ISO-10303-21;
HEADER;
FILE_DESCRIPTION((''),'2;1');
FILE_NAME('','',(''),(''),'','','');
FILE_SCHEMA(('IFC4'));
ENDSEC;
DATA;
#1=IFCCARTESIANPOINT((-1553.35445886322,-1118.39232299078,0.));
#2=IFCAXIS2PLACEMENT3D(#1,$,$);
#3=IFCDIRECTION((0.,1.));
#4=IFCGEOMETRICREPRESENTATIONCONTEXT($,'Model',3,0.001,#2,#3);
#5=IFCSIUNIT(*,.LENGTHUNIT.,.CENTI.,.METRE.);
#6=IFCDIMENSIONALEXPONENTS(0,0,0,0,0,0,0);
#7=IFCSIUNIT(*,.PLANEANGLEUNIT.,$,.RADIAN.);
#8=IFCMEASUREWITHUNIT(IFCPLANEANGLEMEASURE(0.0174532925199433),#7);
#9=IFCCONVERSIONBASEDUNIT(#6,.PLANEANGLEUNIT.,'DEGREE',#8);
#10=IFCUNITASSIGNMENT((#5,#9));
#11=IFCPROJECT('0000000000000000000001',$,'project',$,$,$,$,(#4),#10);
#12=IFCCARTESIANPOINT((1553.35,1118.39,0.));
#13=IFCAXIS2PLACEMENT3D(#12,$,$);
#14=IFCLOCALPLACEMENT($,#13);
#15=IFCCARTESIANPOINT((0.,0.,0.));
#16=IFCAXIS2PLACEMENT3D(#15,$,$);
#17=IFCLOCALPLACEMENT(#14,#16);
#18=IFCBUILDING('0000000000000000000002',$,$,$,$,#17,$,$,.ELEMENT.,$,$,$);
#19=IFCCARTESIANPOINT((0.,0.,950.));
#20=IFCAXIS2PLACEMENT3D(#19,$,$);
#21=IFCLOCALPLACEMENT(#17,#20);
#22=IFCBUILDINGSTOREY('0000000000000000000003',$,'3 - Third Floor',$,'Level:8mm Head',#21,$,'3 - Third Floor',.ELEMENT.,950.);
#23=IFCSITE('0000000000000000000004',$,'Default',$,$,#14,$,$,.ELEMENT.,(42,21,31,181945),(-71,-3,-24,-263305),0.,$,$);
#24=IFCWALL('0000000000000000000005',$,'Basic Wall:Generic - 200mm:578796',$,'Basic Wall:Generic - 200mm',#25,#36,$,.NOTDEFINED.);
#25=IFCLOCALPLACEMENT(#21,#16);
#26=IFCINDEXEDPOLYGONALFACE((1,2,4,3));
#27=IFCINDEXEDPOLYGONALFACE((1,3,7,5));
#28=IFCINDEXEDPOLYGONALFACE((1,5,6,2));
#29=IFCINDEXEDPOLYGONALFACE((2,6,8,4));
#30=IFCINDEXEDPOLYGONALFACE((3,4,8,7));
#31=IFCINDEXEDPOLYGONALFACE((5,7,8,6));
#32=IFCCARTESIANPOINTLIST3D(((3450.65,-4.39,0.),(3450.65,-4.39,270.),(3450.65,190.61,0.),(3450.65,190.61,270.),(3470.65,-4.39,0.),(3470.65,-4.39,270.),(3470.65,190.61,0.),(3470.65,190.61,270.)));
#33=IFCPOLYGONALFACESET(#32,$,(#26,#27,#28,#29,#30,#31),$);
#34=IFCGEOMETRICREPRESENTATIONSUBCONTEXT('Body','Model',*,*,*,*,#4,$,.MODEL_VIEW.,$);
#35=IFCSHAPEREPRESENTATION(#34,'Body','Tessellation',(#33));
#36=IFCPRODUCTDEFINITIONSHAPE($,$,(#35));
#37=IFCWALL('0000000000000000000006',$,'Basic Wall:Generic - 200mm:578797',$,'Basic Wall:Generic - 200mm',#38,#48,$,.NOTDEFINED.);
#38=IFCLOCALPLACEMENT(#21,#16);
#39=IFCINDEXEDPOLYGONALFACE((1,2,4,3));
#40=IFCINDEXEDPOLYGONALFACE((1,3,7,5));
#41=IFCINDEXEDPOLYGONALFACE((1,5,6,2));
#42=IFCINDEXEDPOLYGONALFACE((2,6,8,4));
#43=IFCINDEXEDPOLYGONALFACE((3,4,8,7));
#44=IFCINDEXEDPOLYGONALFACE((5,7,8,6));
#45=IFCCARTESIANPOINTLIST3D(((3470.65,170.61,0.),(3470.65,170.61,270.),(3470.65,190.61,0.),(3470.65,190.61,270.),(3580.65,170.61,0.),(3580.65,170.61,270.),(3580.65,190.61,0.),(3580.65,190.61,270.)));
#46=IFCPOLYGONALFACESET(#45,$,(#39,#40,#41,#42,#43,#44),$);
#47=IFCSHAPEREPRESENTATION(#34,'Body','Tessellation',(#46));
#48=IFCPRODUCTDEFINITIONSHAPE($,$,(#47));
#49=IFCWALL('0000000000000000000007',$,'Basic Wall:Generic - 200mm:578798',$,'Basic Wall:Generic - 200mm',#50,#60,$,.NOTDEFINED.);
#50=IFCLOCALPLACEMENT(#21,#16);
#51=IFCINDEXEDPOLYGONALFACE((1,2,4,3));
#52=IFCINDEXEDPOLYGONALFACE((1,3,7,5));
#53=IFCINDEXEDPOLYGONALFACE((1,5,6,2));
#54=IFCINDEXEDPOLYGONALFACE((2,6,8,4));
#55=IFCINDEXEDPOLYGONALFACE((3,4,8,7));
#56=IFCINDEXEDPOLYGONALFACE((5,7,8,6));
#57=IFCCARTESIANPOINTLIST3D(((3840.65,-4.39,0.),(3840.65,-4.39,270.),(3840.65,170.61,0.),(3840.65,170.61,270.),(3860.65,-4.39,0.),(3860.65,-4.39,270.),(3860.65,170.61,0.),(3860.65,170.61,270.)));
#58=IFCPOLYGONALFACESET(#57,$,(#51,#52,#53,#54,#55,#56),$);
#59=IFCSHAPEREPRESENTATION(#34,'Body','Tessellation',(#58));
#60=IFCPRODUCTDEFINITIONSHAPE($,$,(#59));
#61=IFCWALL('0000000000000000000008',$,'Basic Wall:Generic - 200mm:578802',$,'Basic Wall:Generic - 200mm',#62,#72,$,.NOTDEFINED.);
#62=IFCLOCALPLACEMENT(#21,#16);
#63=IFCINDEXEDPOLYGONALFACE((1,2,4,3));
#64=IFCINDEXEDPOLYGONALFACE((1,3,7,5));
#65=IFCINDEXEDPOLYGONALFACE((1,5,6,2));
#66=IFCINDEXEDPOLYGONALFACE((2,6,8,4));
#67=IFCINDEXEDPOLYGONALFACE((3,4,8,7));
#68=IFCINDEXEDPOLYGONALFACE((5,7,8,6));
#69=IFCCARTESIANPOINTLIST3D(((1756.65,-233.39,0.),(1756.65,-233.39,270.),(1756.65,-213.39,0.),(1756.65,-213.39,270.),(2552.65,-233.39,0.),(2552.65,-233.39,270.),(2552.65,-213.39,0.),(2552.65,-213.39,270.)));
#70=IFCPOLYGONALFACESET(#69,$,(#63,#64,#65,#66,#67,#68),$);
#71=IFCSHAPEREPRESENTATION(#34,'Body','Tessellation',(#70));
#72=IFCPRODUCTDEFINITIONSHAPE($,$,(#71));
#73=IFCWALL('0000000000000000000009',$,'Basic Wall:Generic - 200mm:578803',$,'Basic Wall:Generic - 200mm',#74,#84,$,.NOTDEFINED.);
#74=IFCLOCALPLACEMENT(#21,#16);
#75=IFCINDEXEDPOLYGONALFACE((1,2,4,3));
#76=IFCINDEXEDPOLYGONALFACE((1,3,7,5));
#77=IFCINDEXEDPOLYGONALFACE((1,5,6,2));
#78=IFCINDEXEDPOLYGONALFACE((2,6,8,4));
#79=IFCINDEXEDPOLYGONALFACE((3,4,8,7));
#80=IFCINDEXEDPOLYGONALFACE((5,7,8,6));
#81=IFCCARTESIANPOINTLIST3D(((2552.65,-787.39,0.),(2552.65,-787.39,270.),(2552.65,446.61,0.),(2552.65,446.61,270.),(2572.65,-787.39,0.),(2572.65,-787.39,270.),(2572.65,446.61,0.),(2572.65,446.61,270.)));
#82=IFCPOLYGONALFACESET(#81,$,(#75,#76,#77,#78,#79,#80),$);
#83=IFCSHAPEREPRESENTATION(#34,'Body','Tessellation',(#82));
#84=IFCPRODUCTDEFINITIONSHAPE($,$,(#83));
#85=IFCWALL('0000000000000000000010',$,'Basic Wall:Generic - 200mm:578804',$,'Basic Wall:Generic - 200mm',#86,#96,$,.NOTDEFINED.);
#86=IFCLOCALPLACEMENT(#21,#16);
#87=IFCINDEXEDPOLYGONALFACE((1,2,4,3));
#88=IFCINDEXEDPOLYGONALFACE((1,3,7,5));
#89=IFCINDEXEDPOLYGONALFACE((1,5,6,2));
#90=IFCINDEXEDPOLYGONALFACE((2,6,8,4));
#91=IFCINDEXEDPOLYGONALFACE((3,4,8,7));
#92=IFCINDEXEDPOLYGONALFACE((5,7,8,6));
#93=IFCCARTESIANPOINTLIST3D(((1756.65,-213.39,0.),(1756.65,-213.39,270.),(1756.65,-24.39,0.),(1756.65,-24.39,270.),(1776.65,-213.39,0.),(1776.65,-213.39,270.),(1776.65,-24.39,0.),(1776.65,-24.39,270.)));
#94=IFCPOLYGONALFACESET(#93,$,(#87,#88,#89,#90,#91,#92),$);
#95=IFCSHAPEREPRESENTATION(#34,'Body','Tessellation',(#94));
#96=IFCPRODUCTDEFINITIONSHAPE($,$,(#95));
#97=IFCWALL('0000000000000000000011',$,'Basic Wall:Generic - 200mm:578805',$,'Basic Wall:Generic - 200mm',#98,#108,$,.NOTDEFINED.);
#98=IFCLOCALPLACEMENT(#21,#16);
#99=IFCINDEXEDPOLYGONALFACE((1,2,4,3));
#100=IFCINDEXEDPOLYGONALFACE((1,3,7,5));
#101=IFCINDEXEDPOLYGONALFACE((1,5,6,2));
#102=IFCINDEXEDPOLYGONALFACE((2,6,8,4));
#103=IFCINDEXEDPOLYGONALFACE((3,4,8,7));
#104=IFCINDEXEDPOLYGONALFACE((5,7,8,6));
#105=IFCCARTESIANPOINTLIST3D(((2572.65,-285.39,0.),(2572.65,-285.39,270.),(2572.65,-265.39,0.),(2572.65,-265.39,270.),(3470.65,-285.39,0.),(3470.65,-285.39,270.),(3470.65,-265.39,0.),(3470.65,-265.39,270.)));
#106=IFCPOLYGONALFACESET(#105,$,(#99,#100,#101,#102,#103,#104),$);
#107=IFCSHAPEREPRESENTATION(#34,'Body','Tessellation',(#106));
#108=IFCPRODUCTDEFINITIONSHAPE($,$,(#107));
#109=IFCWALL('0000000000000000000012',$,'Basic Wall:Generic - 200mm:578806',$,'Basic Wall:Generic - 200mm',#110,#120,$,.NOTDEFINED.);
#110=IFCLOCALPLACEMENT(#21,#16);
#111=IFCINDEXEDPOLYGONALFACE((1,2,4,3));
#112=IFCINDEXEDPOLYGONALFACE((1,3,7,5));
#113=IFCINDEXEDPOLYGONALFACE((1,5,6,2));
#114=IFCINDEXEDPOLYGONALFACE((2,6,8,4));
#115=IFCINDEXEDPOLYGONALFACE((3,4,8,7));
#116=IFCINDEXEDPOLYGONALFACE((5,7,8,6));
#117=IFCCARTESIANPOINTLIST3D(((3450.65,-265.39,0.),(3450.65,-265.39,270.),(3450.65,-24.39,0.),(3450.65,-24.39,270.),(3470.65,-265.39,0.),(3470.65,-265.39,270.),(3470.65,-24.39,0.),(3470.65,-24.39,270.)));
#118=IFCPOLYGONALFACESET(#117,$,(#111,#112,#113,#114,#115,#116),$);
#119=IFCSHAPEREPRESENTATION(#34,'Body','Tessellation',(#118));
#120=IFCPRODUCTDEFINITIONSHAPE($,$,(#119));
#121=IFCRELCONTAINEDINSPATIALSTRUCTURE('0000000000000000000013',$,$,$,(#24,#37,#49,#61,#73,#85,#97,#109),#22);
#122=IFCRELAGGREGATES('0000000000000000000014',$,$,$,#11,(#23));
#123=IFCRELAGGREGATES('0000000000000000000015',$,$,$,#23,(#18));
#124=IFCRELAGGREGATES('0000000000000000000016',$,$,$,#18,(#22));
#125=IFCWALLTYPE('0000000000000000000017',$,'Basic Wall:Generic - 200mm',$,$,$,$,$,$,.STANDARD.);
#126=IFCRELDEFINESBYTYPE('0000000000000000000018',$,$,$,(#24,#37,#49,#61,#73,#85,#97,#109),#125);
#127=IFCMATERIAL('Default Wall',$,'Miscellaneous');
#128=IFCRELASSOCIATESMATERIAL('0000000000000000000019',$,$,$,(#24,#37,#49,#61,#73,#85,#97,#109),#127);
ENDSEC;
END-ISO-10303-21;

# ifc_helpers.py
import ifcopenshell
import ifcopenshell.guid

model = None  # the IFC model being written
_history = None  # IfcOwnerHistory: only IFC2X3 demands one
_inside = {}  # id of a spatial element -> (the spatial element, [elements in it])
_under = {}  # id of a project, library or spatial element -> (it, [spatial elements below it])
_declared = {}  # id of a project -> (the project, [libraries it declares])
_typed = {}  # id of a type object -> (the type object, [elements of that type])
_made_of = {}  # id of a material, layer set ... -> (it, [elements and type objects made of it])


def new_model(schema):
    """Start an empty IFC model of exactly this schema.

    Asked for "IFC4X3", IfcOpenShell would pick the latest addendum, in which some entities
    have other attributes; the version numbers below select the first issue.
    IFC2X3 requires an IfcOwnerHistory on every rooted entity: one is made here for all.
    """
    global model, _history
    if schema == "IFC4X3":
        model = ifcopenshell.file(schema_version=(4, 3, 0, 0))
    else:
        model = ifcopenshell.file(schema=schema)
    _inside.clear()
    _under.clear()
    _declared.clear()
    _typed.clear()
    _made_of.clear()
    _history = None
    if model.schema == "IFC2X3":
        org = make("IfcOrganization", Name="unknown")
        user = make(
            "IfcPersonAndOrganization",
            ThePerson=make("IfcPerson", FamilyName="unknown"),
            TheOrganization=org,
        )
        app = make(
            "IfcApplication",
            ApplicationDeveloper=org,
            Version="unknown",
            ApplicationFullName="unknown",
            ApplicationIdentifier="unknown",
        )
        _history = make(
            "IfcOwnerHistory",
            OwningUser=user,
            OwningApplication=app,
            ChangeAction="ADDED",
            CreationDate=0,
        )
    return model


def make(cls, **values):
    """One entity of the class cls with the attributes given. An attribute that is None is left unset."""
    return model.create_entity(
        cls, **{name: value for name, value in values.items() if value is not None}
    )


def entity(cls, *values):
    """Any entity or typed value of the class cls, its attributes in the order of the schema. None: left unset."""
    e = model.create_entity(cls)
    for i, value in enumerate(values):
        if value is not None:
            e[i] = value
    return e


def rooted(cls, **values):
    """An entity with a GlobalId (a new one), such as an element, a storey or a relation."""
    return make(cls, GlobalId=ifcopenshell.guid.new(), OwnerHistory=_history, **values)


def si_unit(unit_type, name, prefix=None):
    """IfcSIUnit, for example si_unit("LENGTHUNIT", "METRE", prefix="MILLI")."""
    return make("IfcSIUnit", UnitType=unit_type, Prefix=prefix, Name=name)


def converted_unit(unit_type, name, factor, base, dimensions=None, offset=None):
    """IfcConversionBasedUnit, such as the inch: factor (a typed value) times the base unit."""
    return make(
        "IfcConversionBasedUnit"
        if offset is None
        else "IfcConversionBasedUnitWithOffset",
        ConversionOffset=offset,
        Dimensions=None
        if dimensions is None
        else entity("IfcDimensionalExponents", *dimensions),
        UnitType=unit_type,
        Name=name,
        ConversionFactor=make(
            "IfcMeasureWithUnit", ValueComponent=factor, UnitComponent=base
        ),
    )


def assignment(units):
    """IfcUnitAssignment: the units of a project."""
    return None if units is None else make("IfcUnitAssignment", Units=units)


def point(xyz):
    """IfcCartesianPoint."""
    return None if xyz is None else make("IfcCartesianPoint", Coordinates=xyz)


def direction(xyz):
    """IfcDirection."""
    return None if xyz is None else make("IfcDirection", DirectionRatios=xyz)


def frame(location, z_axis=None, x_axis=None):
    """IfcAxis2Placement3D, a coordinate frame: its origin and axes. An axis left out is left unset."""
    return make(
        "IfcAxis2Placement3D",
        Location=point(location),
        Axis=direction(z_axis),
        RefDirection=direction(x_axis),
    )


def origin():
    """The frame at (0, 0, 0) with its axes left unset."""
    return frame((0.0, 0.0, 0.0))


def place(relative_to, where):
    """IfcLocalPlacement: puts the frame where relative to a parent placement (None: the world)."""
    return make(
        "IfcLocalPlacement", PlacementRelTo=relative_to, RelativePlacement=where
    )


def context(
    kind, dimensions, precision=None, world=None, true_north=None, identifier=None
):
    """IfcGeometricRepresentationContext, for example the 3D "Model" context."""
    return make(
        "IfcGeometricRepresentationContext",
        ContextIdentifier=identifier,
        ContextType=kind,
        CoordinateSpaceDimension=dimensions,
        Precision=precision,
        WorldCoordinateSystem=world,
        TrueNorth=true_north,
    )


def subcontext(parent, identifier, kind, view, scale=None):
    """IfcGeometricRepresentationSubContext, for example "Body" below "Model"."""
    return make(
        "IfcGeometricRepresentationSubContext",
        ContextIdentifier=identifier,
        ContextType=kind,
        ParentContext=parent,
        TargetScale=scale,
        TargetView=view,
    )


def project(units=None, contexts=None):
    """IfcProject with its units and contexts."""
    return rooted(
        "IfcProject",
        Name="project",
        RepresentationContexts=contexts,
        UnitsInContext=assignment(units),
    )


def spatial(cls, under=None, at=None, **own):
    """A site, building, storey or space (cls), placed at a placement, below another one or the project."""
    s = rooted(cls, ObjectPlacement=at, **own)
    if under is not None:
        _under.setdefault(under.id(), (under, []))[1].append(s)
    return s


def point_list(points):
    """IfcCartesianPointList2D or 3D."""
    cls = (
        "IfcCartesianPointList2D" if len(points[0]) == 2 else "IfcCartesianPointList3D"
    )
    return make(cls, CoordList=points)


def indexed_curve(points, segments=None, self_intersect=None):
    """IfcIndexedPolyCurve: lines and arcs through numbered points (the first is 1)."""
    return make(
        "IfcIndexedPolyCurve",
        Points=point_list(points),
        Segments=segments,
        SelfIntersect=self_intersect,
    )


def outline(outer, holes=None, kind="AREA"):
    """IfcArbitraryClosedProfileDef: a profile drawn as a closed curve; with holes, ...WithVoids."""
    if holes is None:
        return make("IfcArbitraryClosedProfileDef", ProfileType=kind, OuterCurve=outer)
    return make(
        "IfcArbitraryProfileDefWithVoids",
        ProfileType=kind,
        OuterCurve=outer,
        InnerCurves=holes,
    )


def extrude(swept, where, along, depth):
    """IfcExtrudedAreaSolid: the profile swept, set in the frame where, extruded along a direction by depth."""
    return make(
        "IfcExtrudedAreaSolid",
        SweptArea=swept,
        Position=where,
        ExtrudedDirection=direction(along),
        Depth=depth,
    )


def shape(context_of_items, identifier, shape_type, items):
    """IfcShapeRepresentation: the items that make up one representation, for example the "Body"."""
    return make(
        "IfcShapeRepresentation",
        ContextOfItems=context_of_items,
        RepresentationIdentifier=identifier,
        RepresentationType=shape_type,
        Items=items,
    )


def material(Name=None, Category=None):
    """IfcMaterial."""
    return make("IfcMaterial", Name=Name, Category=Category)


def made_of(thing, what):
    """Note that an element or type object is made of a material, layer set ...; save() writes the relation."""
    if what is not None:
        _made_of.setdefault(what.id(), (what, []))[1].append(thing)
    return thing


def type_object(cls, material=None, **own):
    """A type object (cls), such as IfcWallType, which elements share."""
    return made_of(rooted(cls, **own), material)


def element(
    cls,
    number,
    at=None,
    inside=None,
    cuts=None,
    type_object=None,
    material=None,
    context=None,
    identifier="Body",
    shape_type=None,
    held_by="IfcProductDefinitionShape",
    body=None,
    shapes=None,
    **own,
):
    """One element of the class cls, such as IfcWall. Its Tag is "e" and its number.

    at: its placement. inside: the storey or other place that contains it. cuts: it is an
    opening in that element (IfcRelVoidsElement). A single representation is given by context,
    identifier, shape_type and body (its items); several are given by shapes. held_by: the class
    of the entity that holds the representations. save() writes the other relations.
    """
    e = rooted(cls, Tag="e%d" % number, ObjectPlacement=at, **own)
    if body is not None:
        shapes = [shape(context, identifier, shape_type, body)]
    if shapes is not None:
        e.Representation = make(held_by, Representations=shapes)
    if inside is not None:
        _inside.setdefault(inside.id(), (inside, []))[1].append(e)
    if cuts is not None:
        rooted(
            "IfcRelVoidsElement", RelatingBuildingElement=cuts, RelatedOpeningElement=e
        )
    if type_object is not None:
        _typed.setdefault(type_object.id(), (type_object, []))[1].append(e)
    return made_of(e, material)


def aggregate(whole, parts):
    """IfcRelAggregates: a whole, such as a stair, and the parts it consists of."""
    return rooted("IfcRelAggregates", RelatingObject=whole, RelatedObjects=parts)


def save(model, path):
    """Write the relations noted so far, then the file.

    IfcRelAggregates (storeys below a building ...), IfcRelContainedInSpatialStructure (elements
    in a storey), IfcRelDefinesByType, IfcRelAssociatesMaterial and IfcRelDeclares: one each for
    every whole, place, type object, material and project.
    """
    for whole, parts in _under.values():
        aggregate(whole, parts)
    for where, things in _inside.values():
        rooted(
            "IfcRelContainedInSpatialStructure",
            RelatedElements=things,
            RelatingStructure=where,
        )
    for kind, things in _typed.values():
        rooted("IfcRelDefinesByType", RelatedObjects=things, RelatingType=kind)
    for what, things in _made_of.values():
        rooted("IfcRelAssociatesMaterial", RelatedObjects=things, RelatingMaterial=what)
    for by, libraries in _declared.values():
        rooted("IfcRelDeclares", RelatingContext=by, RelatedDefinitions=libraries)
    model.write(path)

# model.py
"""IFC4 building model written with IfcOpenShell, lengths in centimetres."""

from ifc_helpers import new_model, entity, si_unit, converted_unit, direction, frame, origin, place, context, subcontext, project, spatial, indexed_curve, outline, extrude, material, type_object, element, save


model = new_model("IFC4")

# Units and contexts
model_context = context("Model", 3, precision=0.001, world=frame((-1553.35445886322, -1118.39232299078, 0.0)), true_north=direction((0.0, 1.0)))
body_context = subcontext(model_context, "Body", "Model", "MODEL_VIEW")
ifc_project = project(units=[si_unit("LENGTHUNIT", "METRE", prefix="CENTI"), converted_unit("PLANEANGLEUNIT", "DEGREE", entity("IfcPlaneAngleMeasure", 0.0174532925199433), si_unit("PLANEANGLEUNIT", "RADIAN"), dimensions=[0, 0, 0, 0, 0, 0, 0])], contexts=[model_context])

# Site, building, storey
site_placement = place(None, frame((1553.35, 1118.39, 0.0)))
site = spatial("IfcSite", under=ifc_project, at=site_placement, Name="Default", CompositionType="ELEMENT", RefLatitude=(42, 21, 31, 181945), RefLongitude=(-71, -3, -24, -263305), RefElevation=0.0)
building_placement = place(site_placement, origin())
building = spatial("IfcBuilding", under=site, at=building_placement, CompositionType="ELEMENT")
storey_placement = place(building_placement, frame((0.0, 0.0, 950.0)))
storey = spatial("IfcBuildingStorey", under=building, at=storey_placement, Name="3 - Third Floor", ObjectType="Level:8mm Head", LongName="3 - Third Floor", CompositionType="ELEMENT", Elevation=950.0)

# Walls
ifc_material_1 = material(Name="Default Wall", Category="Miscellaneous")
wall_type_1 = type_object("IfcWallType", Name="Basic Wall:Generic - 200mm", PredefinedType="STANDARD")
wall_1_placement = place(storey_placement, frame((3460.65, -4.39, 0.0), z_axis=(0.0, 0.0, 1.0), x_axis=(0.0, 1.0, 0.0)))
element("IfcWall", 1, at=wall_1_placement, inside=storey, type_object=wall_type_1, material=ifc_material_1, Name="Basic Wall:Generic - 200mm:578796", ObjectType="Basic Wall:Generic - 200mm", PredefinedType="NOTDEFINED", context=body_context, shape_type="SweptSolid", body=[
    extrude(outline(indexed_curve([(195.0, 10.0), (0.0, 10.0), (0.0, -10.0), (195.0, -10.0), (195.0, 10.0)], self_intersect=False)), origin(), (0.0, 0.0, 1.0), 270.0),
])
wall_2_placement = place(storey_placement, frame((3470.65, 180.61, 0.0)))
element("IfcWall", 2, at=wall_2_placement, inside=storey, type_object=wall_type_1, material=ifc_material_1, Name="Basic Wall:Generic - 200mm:578797", ObjectType="Basic Wall:Generic - 200mm", PredefinedType="NOTDEFINED", context=body_context, shape_type="SweptSolid", body=[
    extrude(outline(indexed_curve([(110.0, 10.0), (0.0, 10.0), (0.0, -10.0), (110.0, -10.0), (110.0, 10.0)], self_intersect=False)), origin(), (0.0, 0.0, 1.0), 270.0),
])
wall_3_placement = place(storey_placement, frame((3850.65, 170.61, 0.0), z_axis=(0.0, 0.0, 1.0), x_axis=(0.0, -1.0, 0.0)))
element("IfcWall", 3, at=wall_3_placement, inside=storey, type_object=wall_type_1, material=ifc_material_1, Name="Basic Wall:Generic - 200mm:578798", ObjectType="Basic Wall:Generic - 200mm", PredefinedType="NOTDEFINED", context=body_context, shape_type="SweptSolid", body=[
    extrude(outline(indexed_curve([(175.0, 10.0), (0.0, 10.0), (0.0, -10.0), (175.0, -10.0), (175.0, 10.0)], self_intersect=False)), origin(), (0.0, 0.0, 1.0), 270.0),
])
wall_4_placement = place(storey_placement, frame((1756.65, -223.39, 0.0)))
element("IfcWall", 4, at=wall_4_placement, inside=storey, type_object=wall_type_1, material=ifc_material_1, Name="Basic Wall:Generic - 200mm:578802", ObjectType="Basic Wall:Generic - 200mm", PredefinedType="NOTDEFINED", context=body_context, shape_type="SweptSolid", body=[
    extrude(outline(indexed_curve([(796.0, 10.0), (0.0, 10.0), (0.0, -10.0), (796.0, -10.0), (796.0, 10.0)], self_intersect=False)), origin(), (0.0, 0.0, 1.0), 270.0),
])
wall_5_placement = place(storey_placement, frame((2562.65, 446.61, 0.0), z_axis=(0.0, 0.0, 1.0), x_axis=(0.0, -1.0, 0.0)))
element("IfcWall", 5, at=wall_5_placement, inside=storey, type_object=wall_type_1, material=ifc_material_1, Name="Basic Wall:Generic - 200mm:578803", ObjectType="Basic Wall:Generic - 200mm", PredefinedType="NOTDEFINED", context=body_context, shape_type="SweptSolid", body=[
    extrude(outline(indexed_curve([(1234.0, 10.0), (0.0, 10.0), (0.0, -10.0), (1234.0, -10.0), (1234.0, 10.0)], self_intersect=False)), origin(), (0.0, 0.0, 1.0), 270.0),
])
wall_6_placement = place(storey_placement, frame((1766.65, -24.39, 0.0), z_axis=(0.0, 0.0, 1.0), x_axis=(0.0, -1.0, 0.0)))
element("IfcWall", 6, at=wall_6_placement, inside=storey, type_object=wall_type_1, material=ifc_material_1, Name="Basic Wall:Generic - 200mm:578804", ObjectType="Basic Wall:Generic - 200mm", PredefinedType="NOTDEFINED", context=body_context, shape_type="SweptSolid", body=[
    extrude(outline(indexed_curve([(189.0, 10.0), (0.0, 10.0), (0.0, -10.0), (189.0, -10.0), (189.0, 10.0)], self_intersect=False)), origin(), (0.0, 0.0, 1.0), 270.0),
])
wall_7_placement = place(storey_placement, frame((2572.65, -275.39, 0.0)))
element("IfcWall", 7, at=wall_7_placement, inside=storey, type_object=wall_type_1, material=ifc_material_1, Name="Basic Wall:Generic - 200mm:578805", ObjectType="Basic Wall:Generic - 200mm", PredefinedType="NOTDEFINED", context=body_context, shape_type="SweptSolid", body=[
    extrude(outline(indexed_curve([(898.0, 10.0), (0.0, 10.0), (0.0, -10.0), (898.0, -10.0), (898.0, 10.0)], self_intersect=False)), origin(), (0.0, 0.0, 1.0), 270.0),
])
wall_8_placement = place(storey_placement, frame((3460.65, -24.39, 0.0), z_axis=(0.0, 0.0, 1.0), x_axis=(0.0, -1.0, 0.0)))
element("IfcWall", 8, at=wall_8_placement, inside=storey, type_object=wall_type_1, material=ifc_material_1, Name="Basic Wall:Generic - 200mm:578806", ObjectType="Basic Wall:Generic - 200mm", PredefinedType="NOTDEFINED", context=body_context, shape_type="SweptSolid", body=[
    extrude(outline(indexed_curve([(241.0, 10.0), (0.0, 10.0), (0.0, -10.0), (241.0, -10.0), (241.0, 10.0)], self_intersect=False)), origin(), (0.0, 0.0, 1.0), 270.0),
])

save(model, "model.ifc")
